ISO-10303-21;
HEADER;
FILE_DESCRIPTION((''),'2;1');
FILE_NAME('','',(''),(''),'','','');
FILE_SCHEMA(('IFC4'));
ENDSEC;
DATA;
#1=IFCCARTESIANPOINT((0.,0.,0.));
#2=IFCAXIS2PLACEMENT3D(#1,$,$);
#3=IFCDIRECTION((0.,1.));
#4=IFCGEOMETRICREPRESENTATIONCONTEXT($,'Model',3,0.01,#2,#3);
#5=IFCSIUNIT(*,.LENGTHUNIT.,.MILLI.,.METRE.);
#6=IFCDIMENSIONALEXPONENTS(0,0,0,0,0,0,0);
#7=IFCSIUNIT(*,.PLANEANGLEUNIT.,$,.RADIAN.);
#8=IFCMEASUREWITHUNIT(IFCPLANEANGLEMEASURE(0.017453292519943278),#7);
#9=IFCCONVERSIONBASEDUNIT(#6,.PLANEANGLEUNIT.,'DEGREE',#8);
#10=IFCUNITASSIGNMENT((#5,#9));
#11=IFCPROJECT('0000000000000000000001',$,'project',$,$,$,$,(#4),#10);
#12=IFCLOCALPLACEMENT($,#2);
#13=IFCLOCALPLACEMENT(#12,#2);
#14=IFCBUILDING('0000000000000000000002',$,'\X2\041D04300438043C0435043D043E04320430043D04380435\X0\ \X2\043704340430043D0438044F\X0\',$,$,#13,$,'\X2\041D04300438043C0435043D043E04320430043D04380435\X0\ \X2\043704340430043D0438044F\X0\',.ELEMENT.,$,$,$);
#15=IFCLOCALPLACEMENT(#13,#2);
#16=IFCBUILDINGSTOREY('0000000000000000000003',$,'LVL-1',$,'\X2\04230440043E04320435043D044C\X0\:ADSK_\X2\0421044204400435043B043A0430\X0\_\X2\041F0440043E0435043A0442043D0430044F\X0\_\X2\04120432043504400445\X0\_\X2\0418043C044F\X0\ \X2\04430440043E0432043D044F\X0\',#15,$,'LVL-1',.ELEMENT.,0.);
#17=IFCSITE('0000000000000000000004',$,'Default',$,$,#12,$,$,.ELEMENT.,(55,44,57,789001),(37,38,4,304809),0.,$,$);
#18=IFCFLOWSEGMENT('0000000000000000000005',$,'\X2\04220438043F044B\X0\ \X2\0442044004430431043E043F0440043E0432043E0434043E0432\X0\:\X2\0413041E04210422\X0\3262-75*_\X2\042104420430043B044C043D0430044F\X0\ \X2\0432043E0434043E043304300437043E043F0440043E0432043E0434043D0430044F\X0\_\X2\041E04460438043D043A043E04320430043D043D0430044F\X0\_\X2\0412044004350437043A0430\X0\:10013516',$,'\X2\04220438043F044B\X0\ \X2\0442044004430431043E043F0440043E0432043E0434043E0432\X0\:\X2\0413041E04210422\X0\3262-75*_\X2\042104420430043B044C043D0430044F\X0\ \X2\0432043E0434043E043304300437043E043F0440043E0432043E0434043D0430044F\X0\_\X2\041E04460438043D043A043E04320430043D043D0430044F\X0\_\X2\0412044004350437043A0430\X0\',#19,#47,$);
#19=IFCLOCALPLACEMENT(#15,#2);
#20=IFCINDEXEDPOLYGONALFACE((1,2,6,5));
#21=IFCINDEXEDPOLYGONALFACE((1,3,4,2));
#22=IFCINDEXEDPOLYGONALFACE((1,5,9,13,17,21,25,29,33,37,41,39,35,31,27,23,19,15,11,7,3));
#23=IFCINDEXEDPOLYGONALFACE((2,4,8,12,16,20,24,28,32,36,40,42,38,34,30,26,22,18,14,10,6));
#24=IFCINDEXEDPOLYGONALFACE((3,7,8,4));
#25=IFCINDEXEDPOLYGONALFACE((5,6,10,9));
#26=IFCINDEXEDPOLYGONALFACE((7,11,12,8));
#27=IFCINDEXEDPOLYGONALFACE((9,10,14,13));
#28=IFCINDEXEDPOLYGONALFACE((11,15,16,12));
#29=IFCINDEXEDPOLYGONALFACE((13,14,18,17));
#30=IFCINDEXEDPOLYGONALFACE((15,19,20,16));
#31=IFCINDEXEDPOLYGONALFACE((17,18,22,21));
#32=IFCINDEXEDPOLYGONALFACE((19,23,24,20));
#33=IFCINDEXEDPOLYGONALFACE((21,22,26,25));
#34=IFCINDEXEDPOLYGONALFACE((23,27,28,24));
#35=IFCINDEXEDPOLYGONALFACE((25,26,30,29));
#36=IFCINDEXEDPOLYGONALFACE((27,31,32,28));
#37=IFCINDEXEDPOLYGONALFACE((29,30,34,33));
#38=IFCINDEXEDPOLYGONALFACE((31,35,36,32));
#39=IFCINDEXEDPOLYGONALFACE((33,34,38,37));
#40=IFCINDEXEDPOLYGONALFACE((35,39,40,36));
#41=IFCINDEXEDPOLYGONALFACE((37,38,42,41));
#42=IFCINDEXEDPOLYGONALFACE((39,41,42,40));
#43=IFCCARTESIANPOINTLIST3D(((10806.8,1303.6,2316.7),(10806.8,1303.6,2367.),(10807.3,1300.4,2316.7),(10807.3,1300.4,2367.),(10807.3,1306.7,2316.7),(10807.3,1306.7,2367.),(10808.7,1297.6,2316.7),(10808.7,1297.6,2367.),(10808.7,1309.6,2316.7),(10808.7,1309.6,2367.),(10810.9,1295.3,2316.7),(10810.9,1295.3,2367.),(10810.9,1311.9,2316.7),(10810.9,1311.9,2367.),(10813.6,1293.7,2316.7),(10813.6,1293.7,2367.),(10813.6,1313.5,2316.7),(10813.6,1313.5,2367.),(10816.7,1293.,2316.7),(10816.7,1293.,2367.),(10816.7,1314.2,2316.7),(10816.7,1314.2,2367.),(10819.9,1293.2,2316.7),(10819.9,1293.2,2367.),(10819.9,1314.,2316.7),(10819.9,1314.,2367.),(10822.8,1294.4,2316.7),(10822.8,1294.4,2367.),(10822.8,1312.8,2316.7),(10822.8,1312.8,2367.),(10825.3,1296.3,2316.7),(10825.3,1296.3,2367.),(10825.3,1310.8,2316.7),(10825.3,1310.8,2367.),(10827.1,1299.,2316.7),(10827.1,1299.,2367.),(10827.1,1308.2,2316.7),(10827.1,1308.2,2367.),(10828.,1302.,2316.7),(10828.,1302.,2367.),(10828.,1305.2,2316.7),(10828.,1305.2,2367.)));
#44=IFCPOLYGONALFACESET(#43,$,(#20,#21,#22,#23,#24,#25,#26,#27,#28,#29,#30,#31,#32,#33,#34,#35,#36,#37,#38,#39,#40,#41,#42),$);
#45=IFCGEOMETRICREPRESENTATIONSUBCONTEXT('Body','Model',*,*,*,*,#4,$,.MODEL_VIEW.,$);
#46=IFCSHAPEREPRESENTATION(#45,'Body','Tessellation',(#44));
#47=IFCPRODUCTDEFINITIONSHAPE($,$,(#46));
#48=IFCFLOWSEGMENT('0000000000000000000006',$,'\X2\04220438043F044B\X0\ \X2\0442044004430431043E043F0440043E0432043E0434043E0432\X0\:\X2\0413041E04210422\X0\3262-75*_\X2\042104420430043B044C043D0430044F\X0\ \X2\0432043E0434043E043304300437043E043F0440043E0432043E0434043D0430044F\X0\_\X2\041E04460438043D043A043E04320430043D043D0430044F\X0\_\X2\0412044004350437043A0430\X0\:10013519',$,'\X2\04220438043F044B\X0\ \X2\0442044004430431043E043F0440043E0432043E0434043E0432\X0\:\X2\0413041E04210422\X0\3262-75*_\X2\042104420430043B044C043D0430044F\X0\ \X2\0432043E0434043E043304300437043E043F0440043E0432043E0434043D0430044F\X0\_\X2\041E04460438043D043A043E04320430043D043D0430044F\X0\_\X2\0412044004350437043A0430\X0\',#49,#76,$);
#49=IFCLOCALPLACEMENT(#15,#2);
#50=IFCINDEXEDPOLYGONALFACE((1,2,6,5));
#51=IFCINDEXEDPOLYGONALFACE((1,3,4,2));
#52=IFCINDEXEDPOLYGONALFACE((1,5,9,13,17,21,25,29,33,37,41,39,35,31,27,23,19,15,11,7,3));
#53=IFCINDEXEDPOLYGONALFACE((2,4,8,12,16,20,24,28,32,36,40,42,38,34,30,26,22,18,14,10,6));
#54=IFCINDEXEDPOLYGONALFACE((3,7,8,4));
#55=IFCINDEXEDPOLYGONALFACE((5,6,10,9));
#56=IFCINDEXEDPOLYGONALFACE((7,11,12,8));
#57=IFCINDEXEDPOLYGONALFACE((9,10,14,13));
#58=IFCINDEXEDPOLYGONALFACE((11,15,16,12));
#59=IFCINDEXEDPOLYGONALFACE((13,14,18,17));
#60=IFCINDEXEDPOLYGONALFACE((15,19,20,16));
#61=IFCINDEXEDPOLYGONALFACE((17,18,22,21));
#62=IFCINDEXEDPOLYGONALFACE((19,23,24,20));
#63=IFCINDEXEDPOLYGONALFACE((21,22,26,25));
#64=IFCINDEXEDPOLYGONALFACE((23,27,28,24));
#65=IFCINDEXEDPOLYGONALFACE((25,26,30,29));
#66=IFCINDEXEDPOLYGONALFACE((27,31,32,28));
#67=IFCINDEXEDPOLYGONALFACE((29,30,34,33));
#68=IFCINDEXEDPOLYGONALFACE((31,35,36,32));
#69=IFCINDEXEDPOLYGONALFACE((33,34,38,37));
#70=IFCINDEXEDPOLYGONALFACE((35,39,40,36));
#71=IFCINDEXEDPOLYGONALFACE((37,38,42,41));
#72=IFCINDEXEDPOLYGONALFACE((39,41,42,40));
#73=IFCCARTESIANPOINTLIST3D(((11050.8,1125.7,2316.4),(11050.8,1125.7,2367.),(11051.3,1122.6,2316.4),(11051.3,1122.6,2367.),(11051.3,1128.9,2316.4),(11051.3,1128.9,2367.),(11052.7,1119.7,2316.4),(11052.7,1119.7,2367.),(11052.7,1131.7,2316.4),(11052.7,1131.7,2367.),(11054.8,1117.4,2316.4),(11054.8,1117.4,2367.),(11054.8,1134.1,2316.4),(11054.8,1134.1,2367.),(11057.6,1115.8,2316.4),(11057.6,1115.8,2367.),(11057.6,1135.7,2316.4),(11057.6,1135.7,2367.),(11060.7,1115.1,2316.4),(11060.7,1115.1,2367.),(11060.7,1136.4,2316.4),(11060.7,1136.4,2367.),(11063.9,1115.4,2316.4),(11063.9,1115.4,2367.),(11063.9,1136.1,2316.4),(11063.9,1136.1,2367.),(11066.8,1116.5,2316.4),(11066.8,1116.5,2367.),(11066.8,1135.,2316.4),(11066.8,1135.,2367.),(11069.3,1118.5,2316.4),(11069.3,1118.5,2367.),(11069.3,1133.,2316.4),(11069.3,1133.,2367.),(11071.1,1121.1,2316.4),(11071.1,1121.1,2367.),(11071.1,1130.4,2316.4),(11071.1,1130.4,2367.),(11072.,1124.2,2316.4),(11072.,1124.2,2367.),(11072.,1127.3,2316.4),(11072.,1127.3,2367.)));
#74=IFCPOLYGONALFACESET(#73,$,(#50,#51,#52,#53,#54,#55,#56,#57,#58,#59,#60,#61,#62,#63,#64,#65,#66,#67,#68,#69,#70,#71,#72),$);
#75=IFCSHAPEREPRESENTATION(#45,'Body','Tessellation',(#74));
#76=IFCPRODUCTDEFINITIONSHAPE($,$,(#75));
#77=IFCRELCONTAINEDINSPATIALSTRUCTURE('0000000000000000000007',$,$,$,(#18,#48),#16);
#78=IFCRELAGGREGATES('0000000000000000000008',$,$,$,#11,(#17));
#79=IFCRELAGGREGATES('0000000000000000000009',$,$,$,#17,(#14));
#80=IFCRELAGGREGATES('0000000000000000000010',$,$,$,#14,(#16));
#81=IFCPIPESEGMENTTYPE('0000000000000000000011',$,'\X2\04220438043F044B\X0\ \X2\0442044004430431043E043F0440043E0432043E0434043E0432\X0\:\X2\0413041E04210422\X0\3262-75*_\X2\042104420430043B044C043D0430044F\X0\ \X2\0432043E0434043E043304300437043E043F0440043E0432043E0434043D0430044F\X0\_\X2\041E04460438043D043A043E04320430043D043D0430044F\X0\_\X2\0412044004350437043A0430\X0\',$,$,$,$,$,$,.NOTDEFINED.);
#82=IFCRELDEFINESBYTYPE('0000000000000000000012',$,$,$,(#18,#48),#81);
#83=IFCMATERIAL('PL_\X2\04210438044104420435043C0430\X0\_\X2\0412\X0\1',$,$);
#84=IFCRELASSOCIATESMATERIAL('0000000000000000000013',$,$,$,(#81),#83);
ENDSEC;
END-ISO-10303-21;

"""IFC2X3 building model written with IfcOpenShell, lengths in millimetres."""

from ifc_helpers import new_model, entity, si_unit, converted_unit, direction, frame, origin, origin_2d_with_axis, place, context, subcontext, project, spatial, circle, extrude, material, type_object, element, save


model = new_model("IFC2X3")

# Units and contexts
model_context = context("Model", 3, precision=0.01, world=origin(), true_north=direction((0.0, 1.0)))
body_context = subcontext(model_context, "Body", "Model", "MODEL_VIEW")
ifc_project = project(units=[si_unit("LENGTHUNIT", "METRE", prefix="MILLI"), converted_unit("PLANEANGLEUNIT", "DEGREE", entity("IfcPlaneAngleMeasure", 0.017453292519943278), si_unit("PLANEANGLEUNIT", "RADIAN"), dimensions=[0, 0, 0, 0, 0, 0, 0])], contexts=[model_context])

# Site, building, storey
site_placement = place(None, origin())
site = spatial("IfcSite", under=ifc_project, at=site_placement, Name="Default", CompositionType="ELEMENT", RefLatitude=(55, 44, 57, 789001), RefLongitude=(37, 38, 4, 304809), RefElevation=0.0)
building_placement = place(site_placement, origin())
building = spatial("IfcBuilding", under=site, at=building_placement, Name="Наименование здания", LongName="Наименование здания", CompositionType="ELEMENT")
storey_placement = place(building_placement, origin())
storey = spatial("IfcBuildingStorey", under=building, at=storey_placement, Name="LVL-1", ObjectType="Уровень:ADSK_Стрелка_Проектная_Вверх_Имя уровня", LongName="LVL-1", CompositionType="ELEMENT", Elevation=0.0)

# Flow segments
ifc_material_1 = material(Name="PL_Система_В1")
pipe_segment_type_1 = type_object("IfcPipeSegmentType", Name="Типы трубопроводов:ГОСТ3262-75*_Стальная водогазопроводная_Оцинкованная_Врезка", PredefinedType="NOTDEFINED", material=ifc_material_1)
flow_segment_1_placement = place(storey_placement, origin())
element("IfcFlowSegment", 1, at=flow_segment_1_placement, inside=storey, type_object=pipe_segment_type_1, Name="Типы трубопроводов:ГОСТ3262-75*_Стальная водогазопроводная_Оцинкованная_Врезка:10013516", ObjectType="Типы трубопроводов:ГОСТ3262-75*_Стальная водогазопроводная_Оцинкованная_Врезка", context=body_context, shape_type="SweptSolid", body=[
    extrude(circle(Radius=10.7, at=origin_2d_with_axis()), frame((10817.5, 1303.6, 2316.7), z_axis=(0.0, 0.0, 1.0), x_axis=(-1.0, 0.0, 0.0)), (0.0, 0.0, 1.0), 50.3),
])
flow_segment_2_placement = place(storey_placement, origin())
element("IfcFlowSegment", 2, at=flow_segment_2_placement, inside=storey, type_object=pipe_segment_type_1, Name="Типы трубопроводов:ГОСТ3262-75*_Стальная водогазопроводная_Оцинкованная_Врезка:10013519", ObjectType="Типы трубопроводов:ГОСТ3262-75*_Стальная водогазопроводная_Оцинкованная_Врезка", context=body_context, shape_type="SweptSolid", body=[
    extrude(circle(Radius=10.7, at=origin_2d_with_axis()), frame((11061.5, 1125.7, 2316.4), z_axis=(0.0, 0.0, 1.0), x_axis=(-1.0, 0.0, 0.0)), (0.0, 0.0, 1.0), 50.6),
])

save(model, "model.ifc")
